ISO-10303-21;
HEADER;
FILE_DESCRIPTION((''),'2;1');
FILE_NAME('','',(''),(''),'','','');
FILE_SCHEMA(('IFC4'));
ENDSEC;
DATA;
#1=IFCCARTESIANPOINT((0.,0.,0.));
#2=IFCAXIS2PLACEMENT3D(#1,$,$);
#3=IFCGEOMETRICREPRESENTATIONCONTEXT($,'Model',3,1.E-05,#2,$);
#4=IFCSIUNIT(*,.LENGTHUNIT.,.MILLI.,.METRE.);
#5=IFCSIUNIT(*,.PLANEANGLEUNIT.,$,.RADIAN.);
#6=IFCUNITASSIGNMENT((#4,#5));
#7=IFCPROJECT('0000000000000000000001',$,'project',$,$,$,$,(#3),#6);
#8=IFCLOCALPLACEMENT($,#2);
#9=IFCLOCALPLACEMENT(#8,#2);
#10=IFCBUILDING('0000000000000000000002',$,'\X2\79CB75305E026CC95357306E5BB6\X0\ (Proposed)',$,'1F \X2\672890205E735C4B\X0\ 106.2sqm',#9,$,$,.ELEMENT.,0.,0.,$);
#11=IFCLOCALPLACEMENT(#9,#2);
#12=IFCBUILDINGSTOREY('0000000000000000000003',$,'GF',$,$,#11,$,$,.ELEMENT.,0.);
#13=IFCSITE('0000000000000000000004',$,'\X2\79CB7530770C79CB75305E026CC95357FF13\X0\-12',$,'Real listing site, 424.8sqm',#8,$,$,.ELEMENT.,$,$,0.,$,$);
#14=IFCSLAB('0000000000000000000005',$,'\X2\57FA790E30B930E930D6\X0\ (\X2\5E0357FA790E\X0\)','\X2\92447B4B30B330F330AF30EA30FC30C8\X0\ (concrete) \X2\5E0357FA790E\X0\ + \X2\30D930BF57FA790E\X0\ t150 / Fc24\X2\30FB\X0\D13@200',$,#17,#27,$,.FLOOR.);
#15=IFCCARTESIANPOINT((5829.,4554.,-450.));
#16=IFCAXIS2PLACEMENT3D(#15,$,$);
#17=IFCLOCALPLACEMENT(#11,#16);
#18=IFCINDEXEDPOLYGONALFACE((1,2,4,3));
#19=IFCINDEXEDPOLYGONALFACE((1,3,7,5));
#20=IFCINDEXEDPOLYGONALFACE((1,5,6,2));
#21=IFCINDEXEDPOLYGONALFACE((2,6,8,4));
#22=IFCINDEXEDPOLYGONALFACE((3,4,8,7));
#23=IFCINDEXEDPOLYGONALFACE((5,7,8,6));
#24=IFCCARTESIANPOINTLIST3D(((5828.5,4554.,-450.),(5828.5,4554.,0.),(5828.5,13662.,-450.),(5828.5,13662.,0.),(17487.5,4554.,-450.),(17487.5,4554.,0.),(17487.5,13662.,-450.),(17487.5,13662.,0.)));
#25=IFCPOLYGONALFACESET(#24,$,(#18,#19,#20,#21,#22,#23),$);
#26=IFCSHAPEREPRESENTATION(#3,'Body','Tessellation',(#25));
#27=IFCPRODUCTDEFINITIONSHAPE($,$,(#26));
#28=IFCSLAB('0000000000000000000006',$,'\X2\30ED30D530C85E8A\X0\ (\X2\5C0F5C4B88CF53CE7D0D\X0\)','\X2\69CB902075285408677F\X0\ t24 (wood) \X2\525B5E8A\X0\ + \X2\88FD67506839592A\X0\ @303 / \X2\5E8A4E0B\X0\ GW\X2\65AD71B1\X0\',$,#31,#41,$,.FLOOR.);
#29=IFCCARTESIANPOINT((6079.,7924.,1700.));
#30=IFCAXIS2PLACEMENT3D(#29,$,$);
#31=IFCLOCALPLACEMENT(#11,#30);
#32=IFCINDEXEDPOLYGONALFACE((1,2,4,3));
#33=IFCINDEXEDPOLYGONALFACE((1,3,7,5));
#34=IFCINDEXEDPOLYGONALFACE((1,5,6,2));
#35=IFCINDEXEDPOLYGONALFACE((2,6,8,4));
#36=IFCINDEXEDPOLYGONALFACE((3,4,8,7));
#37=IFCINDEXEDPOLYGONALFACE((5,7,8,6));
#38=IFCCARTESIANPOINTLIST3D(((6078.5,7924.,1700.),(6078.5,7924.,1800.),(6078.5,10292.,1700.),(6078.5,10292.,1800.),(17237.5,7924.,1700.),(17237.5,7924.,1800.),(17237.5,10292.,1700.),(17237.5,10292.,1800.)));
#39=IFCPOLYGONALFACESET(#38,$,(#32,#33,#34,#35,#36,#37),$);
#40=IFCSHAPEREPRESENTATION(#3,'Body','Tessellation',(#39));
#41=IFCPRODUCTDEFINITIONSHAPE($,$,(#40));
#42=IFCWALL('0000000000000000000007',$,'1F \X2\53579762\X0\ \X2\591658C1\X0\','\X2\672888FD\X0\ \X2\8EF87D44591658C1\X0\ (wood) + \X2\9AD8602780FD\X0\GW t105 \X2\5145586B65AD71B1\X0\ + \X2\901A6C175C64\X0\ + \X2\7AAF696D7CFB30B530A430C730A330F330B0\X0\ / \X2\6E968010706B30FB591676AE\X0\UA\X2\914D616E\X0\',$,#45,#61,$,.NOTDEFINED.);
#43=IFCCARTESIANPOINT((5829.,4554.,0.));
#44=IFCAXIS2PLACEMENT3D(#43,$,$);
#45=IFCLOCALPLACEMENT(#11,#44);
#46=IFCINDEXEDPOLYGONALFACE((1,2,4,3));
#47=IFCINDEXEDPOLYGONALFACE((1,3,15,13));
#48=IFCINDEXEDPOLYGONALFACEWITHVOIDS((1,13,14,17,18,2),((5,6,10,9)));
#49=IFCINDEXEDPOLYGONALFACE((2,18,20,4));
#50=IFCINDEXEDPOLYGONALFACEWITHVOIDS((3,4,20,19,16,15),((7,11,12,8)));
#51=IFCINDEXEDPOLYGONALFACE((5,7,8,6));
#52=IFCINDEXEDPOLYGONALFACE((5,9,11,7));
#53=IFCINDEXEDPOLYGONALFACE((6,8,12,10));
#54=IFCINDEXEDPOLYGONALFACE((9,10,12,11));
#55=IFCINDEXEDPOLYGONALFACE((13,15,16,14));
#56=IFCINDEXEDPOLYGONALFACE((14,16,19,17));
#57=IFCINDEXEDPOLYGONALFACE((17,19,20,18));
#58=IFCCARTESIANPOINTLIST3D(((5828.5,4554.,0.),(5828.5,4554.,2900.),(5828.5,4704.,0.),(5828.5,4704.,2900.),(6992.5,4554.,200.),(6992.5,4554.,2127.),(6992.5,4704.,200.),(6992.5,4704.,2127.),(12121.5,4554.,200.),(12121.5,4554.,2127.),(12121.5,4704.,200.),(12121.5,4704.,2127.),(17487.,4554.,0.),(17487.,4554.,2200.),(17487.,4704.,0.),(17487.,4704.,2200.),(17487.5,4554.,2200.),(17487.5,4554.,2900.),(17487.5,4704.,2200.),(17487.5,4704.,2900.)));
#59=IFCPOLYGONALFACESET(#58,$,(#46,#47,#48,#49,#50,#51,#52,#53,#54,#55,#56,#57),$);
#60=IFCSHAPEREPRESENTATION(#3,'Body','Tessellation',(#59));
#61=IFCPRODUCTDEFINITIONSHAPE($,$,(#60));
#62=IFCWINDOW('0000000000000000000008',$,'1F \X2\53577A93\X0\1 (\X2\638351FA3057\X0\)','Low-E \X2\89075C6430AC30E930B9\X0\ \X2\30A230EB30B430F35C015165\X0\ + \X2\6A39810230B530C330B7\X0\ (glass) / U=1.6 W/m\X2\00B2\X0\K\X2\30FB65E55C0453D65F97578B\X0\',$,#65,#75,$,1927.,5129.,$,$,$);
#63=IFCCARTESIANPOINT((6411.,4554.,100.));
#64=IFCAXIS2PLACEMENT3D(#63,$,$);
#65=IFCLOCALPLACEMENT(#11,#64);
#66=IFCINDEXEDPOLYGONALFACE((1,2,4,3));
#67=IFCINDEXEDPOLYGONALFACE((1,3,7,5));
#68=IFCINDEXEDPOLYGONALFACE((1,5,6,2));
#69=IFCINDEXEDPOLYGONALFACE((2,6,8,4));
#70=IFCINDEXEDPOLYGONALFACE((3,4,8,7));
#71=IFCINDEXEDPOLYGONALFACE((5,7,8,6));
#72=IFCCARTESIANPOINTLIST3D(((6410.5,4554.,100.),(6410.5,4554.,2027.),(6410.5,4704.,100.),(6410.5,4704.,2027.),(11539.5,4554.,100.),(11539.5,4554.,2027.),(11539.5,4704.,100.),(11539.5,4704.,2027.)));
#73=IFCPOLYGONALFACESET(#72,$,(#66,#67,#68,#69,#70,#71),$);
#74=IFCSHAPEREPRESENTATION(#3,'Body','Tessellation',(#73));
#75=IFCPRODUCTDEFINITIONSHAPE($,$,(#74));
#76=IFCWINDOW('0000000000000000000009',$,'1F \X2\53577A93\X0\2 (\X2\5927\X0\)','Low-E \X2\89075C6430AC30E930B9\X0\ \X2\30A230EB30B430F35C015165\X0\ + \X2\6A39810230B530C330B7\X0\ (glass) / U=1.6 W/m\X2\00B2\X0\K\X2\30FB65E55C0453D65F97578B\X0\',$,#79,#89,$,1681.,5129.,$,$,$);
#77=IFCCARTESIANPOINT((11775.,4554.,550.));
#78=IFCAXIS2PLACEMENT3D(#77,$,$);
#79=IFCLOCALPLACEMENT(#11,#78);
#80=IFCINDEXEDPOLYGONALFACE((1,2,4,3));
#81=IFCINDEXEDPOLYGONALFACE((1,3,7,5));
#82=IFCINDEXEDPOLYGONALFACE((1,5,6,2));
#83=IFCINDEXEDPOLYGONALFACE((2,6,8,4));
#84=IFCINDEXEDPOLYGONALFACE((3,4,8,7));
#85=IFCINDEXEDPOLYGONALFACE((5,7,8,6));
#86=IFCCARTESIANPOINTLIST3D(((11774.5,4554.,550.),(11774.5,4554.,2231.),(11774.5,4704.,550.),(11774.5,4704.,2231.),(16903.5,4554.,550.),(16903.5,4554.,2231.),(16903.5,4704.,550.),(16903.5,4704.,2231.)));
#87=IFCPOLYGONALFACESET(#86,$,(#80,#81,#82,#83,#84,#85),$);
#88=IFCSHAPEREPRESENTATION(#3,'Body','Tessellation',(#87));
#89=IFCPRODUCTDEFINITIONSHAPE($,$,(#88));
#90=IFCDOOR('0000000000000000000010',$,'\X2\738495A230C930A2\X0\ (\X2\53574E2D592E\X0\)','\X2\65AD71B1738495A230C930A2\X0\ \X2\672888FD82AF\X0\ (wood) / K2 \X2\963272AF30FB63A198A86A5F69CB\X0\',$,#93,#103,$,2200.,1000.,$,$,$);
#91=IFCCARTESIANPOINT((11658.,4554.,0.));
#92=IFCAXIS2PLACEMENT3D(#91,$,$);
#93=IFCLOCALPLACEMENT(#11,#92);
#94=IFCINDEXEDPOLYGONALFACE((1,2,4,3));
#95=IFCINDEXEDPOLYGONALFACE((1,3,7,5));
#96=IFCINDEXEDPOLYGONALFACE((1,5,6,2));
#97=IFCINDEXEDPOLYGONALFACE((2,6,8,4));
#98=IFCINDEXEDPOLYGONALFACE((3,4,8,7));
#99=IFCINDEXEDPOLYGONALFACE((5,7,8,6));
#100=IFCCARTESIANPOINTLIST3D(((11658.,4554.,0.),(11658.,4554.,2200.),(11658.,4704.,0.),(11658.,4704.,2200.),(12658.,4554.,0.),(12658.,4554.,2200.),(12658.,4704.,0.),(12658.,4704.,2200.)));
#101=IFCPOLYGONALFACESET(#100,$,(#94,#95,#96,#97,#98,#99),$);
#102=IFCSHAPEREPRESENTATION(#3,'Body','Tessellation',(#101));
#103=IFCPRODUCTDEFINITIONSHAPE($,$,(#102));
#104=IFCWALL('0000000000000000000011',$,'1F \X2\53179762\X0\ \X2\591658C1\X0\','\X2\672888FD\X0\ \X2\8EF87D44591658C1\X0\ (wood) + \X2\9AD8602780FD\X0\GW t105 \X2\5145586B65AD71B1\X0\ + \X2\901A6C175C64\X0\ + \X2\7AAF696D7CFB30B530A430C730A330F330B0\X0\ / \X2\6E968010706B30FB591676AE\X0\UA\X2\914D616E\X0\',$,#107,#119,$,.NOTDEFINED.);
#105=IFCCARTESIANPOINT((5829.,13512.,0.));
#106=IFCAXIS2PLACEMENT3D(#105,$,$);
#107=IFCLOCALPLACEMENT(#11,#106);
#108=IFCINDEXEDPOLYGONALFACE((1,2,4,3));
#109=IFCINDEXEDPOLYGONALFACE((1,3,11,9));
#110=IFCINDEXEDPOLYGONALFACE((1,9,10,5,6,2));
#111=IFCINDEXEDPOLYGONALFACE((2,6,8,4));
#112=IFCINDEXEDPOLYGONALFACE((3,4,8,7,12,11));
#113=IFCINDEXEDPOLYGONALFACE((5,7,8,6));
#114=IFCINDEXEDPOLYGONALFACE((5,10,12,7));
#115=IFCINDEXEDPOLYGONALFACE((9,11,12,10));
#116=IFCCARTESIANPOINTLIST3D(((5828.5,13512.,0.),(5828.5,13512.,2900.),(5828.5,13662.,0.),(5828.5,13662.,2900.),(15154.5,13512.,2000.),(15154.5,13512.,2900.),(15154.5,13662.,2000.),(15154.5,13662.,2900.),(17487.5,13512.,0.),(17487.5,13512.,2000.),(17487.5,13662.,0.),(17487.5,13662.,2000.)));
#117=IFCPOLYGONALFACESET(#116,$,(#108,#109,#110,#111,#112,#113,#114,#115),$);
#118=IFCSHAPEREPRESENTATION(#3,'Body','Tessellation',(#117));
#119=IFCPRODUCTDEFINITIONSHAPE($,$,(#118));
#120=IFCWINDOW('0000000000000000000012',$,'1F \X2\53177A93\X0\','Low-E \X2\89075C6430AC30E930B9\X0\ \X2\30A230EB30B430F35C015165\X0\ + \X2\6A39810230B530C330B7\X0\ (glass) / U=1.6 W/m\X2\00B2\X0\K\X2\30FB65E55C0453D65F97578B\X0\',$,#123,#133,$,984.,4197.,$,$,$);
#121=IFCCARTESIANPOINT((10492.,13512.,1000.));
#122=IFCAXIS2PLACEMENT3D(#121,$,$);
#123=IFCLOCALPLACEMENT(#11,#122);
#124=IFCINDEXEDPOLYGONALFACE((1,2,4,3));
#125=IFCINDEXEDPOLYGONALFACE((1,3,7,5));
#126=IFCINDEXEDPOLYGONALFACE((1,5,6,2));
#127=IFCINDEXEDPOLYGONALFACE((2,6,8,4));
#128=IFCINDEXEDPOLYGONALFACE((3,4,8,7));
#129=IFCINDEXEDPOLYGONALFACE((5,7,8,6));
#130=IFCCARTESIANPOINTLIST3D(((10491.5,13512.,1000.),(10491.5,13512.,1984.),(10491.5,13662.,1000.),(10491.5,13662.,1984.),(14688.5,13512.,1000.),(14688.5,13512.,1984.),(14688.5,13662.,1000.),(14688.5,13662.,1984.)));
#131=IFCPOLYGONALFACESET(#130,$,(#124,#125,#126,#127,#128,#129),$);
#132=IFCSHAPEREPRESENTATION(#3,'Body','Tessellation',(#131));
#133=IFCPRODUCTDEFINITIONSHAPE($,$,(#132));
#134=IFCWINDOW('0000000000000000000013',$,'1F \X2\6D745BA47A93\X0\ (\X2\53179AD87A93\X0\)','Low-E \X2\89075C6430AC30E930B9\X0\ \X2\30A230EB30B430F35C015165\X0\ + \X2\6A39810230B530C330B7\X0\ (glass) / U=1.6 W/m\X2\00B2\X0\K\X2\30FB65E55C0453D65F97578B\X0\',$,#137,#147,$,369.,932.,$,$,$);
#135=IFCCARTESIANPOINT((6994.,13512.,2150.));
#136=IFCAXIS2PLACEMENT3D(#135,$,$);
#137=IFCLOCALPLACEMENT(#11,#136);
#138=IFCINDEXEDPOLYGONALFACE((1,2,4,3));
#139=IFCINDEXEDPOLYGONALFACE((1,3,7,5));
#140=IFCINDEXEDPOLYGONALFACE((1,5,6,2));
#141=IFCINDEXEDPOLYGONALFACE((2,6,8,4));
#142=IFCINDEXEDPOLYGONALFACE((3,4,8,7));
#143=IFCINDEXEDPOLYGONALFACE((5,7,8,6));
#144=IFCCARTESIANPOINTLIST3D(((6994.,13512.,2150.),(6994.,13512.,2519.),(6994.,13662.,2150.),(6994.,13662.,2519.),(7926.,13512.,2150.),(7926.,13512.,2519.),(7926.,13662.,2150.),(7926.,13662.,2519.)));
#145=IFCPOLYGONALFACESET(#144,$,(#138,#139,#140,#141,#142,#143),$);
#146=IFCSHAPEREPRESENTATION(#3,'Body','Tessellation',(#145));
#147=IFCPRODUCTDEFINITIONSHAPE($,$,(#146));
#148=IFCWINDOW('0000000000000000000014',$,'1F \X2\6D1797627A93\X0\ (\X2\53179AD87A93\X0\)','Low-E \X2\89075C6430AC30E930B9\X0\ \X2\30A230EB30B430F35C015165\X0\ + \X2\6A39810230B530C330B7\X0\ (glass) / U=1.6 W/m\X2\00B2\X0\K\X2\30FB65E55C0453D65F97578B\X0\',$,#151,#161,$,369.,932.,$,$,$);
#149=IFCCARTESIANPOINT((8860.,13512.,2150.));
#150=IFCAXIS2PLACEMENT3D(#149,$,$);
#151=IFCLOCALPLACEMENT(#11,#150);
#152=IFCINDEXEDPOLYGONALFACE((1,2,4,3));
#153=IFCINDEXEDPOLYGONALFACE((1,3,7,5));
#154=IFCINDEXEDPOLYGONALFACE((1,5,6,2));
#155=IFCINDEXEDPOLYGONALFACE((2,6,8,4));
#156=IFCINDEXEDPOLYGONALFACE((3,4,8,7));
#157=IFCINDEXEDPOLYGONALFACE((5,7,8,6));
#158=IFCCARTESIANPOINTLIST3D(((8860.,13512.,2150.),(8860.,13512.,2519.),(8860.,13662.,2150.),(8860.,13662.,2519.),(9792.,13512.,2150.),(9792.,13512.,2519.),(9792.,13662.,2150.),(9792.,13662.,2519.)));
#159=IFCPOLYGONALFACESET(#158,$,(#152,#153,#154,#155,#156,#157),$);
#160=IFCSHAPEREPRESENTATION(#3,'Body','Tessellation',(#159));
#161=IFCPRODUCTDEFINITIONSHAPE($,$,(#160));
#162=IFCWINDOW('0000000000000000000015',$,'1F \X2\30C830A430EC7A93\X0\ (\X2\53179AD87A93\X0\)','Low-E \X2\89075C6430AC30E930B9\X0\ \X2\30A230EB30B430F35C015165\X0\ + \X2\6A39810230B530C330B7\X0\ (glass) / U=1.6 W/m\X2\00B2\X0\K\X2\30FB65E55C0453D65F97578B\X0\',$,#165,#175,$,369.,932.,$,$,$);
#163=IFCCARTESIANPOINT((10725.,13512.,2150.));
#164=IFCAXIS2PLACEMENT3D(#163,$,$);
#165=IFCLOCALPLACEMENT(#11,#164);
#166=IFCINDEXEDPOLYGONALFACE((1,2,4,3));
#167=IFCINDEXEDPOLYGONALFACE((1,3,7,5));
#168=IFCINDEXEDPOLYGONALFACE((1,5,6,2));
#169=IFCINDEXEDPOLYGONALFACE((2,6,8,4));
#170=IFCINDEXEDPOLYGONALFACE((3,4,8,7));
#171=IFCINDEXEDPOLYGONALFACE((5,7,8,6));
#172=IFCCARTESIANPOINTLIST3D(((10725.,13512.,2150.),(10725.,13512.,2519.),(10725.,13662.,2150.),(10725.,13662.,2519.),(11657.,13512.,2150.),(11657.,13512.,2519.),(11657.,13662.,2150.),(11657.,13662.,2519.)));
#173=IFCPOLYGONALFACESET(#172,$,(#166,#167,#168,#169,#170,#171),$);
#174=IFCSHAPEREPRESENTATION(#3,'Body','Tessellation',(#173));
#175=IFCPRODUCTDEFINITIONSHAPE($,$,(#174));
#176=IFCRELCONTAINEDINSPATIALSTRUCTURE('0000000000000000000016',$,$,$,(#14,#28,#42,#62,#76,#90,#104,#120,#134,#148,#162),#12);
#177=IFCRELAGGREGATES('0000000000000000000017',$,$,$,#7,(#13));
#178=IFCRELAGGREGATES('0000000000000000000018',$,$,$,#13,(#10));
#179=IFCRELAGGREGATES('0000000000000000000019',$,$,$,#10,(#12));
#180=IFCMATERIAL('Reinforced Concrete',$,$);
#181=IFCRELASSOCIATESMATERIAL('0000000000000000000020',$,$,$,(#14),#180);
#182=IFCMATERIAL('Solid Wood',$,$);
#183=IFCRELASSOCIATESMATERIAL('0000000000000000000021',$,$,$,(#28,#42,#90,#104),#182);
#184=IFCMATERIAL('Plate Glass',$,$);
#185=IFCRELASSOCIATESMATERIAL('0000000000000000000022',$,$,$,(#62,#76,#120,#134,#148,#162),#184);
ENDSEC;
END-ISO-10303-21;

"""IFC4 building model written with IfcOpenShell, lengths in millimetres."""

from ifc_helpers import new_model, si_unit, frame, frame_2d, origin, place, context, project, spatial, rectangle, extrude, material, element, fill, save


model = new_model("IFC4")

# Units and contexts
model_context = context("Model", 3, precision=1e-05, world=origin())
ifc_project = project(units=[si_unit("LENGTHUNIT", "METRE", prefix="MILLI"), si_unit("PLANEANGLEUNIT", "RADIAN")], contexts=[model_context])

# Site, building, storey
site_placement = place(None, origin())
site = spatial("IfcSite", under=ifc_project, at=site_placement, Name="秋田県秋田市泉南３-12", ObjectType="Real listing site, 424.8sqm", CompositionType="ELEMENT", RefElevation=0.0)
building_placement = place(site_placement, origin())
building = spatial("IfcBuilding", under=site, at=building_placement, Name="秋田市泉南の家 (Proposed)", ObjectType="1F 木造平屋 106.2sqm", CompositionType="ELEMENT", ElevationOfRefHeight=0.0, ElevationOfTerrain=0.0)
storey_placement = place(building_placement, origin())
storey = spatial("IfcBuildingStorey", under=building, at=storey_placement, Name="GF", CompositionType="ELEMENT", Elevation=0.0)

# Slabs
ifc_material_1 = material(Name="Reinforced Concrete")
slab_1_placement = place(storey_placement, frame((5829.0, 4554.0, -450.0)))
element("IfcSlab", 1, at=slab_1_placement, inside=storey, material=ifc_material_1, Name="基礎スラブ (布基礎)", Description="鉄筋コンクリート (concrete) 布基礎 + ベタ基礎 t150 / Fc24・D13@200", PredefinedType="FLOOR", context=model_context, shape_type="SweptSolid", body=[
    extrude(rectangle(XDim=11659.0, YDim=9108.0, at=frame_2d((5829.0, 4554.0))), frame((5829.0, 4554.0, -450.0)), (0.0, 0.0, 1.0), 450.0),
])
ifc_material_2 = material(Name="Solid Wood")
slab_2_placement = place(storey_placement, frame((6079.0, 7924.0, 1700.0)))
element("IfcSlab", 2, at=slab_2_placement, inside=storey, material=ifc_material_2, Name="ロフト床 (小屋裏収納)", Description="構造用合板 t24 (wood) 剛床 + 製材根太 @303 / 床下 GW断熱", PredefinedType="FLOOR", context=model_context, shape_type="SweptSolid", body=[
    extrude(rectangle(XDim=11159.0, YDim=2368.0, at=frame_2d((5579.0, 1184.0))), frame((6079.0, 7924.0, 1700.0)), (0.0, 0.0, 1.0), 100.0),
])

# Wall, openings, windows, door
wall_1_placement = place(storey_placement, frame((5829.0, 4554.0, 0.0)))
wall_1 = element("IfcWall", 3, at=wall_1_placement, inside=storey, material=ifc_material_2, Name="1F 南面 外壁", Description="木製 軸組外壁 (wood) + 高性能GW t105 充填断熱 + 通気層 + 窯業系サイディング / 準耐火・外皮UA配慮", PredefinedType="NOTDEFINED", context=model_context, shape_type="SweptSolid", body=[
    extrude(rectangle(XDim=11659.0, YDim=150.0, at=frame_2d((5829.0, 75.0))), frame((5829.0, 4554.0, 0.0)), (0.0, 0.0, 1.0), 2900.0),
])
opening_1_placement = place(storey_placement, frame((6411.0, 4554.0, 100.0)))
opening_1 = element("IfcOpeningElement", 4, at=opening_1_placement, cuts=wall_1, PredefinedType="NOTDEFINED", context=model_context, shape_type="SweptSolid", body=[
    extrude(rectangle(XDim=5129.0, YDim=150.0, at=frame_2d((2564.0, 75.0))), frame((6411.0, 4554.0, 100.0)), (0.0, 0.0, 1.0), 1927.0),
])
opening_2_placement = place(storey_placement, frame((11775.0, 4554.0, 550.0)))
opening_2 = element("IfcOpeningElement", 5, at=opening_2_placement, cuts=wall_1, PredefinedType="NOTDEFINED", context=model_context, shape_type="SweptSolid", body=[
    extrude(rectangle(XDim=5129.0, YDim=150.0, at=frame_2d((2564.0, 75.0))), frame((11775.0, 4554.0, 550.0)), (0.0, 0.0, 1.0), 1681.0),
])
opening_3_placement = place(storey_placement, frame((11658.0, 4554.0, 0.0)))
opening_3 = element("IfcOpeningElement", 6, at=opening_3_placement, cuts=wall_1, PredefinedType="NOTDEFINED", context=model_context, shape_type="SweptSolid", body=[
    extrude(rectangle(XDim=1000.0, YDim=150.0, at=frame_2d((500.0, 75.0))), frame((11658.0, 4554.0, 0.0)), (0.0, 0.0, 1.0), 2200.0),
])
ifc_material_3 = material(Name="Plate Glass")
window_1_placement = place(storey_placement, frame((6411.0, 4554.0, 100.0)))
window_1 = element("IfcWindow", 7, at=window_1_placement, inside=storey, material=ifc_material_3, Name="1F 南窓1 (掃出し)", Description="Low-E 複層ガラス アルゴン封入 + 樹脂サッシ (glass) / U=1.6 W/m²K・日射取得型", OverallHeight=1927.0, OverallWidth=5129.0, context=model_context, shape_type="SweptSolid", body=[
    extrude(rectangle(XDim=5129.0, YDim=150.0, at=frame_2d((2564.0, 75.0))), frame((6411.0, 4554.0, 100.0)), (0.0, 0.0, 1.0), 1927.0),
])
fill(opening_1, window_1)
window_2_placement = place(storey_placement, frame((11775.0, 4554.0, 550.0)))
window_2 = element("IfcWindow", 8, at=window_2_placement, inside=storey, material=ifc_material_3, Name="1F 南窓2 (大)", Description="Low-E 複層ガラス アルゴン封入 + 樹脂サッシ (glass) / U=1.6 W/m²K・日射取得型", OverallHeight=1681.0, OverallWidth=5129.0, context=model_context, shape_type="SweptSolid", body=[
    extrude(rectangle(XDim=5129.0, YDim=150.0, at=frame_2d((2564.0, 75.0))), frame((11775.0, 4554.0, 550.0)), (0.0, 0.0, 1.0), 1681.0),
])
fill(opening_2, window_2)
door_1_placement = place(storey_placement, frame((11658.0, 4554.0, 0.0)))
door_1 = element("IfcDoor", 9, at=door_1_placement, inside=storey, material=ifc_material_2, Name="玄関ドア (南中央)", Description="断熱玄関ドア 木製芯 (wood) / K2 防犯・採風機構", OverallHeight=2200.0, OverallWidth=1000.0, context=model_context, shape_type="SweptSolid", body=[
    extrude(rectangle(XDim=1000.0, YDim=150.0, at=frame_2d((500.0, 75.0))), frame((11658.0, 4554.0, 0.0)), (0.0, 0.0, 1.0), 2200.0),
])
fill(opening_3, door_1)

# Wall, openings, windows
wall_2_placement = place(storey_placement, frame((5829.0, 13512.0, 0.0)))
wall_2 = element("IfcWall", 10, at=wall_2_placement, inside=storey, material=ifc_material_2, Name="1F 北面 外壁", Description="木製 軸組外壁 (wood) + 高性能GW t105 充填断熱 + 通気層 + 窯業系サイディング / 準耐火・外皮UA配慮", PredefinedType="NOTDEFINED", context=model_context, shape_type="SweptSolid", body=[
    extrude(rectangle(XDim=11659.0, YDim=150.0, at=frame_2d((5829.0, 75.0))), frame((5829.0, 13512.0, 0.0)), (0.0, 0.0, 1.0), 2900.0),
])
opening_4_placement = place(storey_placement, frame((10492.0, 13512.0, 1000.0)))
opening_4 = element("IfcOpeningElement", 11, at=opening_4_placement, cuts=wall_2, PredefinedType="NOTDEFINED", context=model_context, shape_type="SweptSolid", body=[
    extrude(rectangle(XDim=4197.0, YDim=150.0, at=frame_2d((2098.0, 75.0))), frame((10492.0, 13512.0, 1000.0)), (0.0, 0.0, 1.0), 984.0),
])
opening_5_placement = place(storey_placement, frame((6994.0, 13512.0, 2150.0)))
opening_5 = element("IfcOpeningElement", 12, at=opening_5_placement, cuts=wall_2, PredefinedType="NOTDEFINED", context=model_context, shape_type="SweptSolid", body=[
    extrude(rectangle(XDim=932.0, YDim=150.0, at=frame_2d((466.0, 75.0))), frame((6994.0, 13512.0, 2150.0)), (0.0, 0.0, 1.0), 369.0),
])
opening_6_placement = place(storey_placement, frame((8860.0, 13512.0, 2150.0)))
opening_6 = element("IfcOpeningElement", 13, at=opening_6_placement, cuts=wall_2, PredefinedType="NOTDEFINED", context=model_context, shape_type="SweptSolid", body=[
    extrude(rectangle(XDim=932.0, YDim=150.0, at=frame_2d((466.0, 75.0))), frame((8860.0, 13512.0, 2150.0)), (0.0, 0.0, 1.0), 369.0),
])
opening_7_placement = place(storey_placement, frame((10725.0, 13512.0, 2150.0)))
opening_7 = element("IfcOpeningElement", 14, at=opening_7_placement, cuts=wall_2, PredefinedType="NOTDEFINED", context=model_context, shape_type="SweptSolid", body=[
    extrude(rectangle(XDim=932.0, YDim=150.0, at=frame_2d((466.0, 75.0))), frame((10725.0, 13512.0, 2150.0)), (0.0, 0.0, 1.0), 369.0),
])
window_3_placement = place(storey_placement, frame((10492.0, 13512.0, 1000.0)))
window_3 = element("IfcWindow", 15, at=window_3_placement, inside=storey, material=ifc_material_3, Name="1F 北窓", Description="Low-E 複層ガラス アルゴン封入 + 樹脂サッシ (glass) / U=1.6 W/m²K・日射取得型", OverallHeight=984.0, OverallWidth=4197.0, context=model_context, shape_type="SweptSolid", body=[
    extrude(rectangle(XDim=4197.0, YDim=150.0, at=frame_2d((2098.0, 75.0))), frame((10492.0, 13512.0, 1000.0)), (0.0, 0.0, 1.0), 984.0),
])
fill(opening_4, window_3)
window_4_placement = place(storey_placement, frame((6994.0, 13512.0, 2150.0)))
window_4 = element("IfcWindow", 16, at=window_4_placement, inside=storey, material=ifc_material_3, Name="1F 浴室窓 (北高窓)", Description="Low-E 複層ガラス アルゴン封入 + 樹脂サッシ (glass) / U=1.6 W/m²K・日射取得型", OverallHeight=369.0, OverallWidth=932.0, context=model_context, shape_type="SweptSolid", body=[
    extrude(rectangle(XDim=932.0, YDim=150.0, at=frame_2d((466.0, 75.0))), frame((6994.0, 13512.0, 2150.0)), (0.0, 0.0, 1.0), 369.0),
])
fill(opening_5, window_4)
window_5_placement = place(storey_placement, frame((8860.0, 13512.0, 2150.0)))
window_5 = element("IfcWindow", 17, at=window_5_placement, inside=storey, material=ifc_material_3, Name="1F 洗面窓 (北高窓)", Description="Low-E 複層ガラス アルゴン封入 + 樹脂サッシ (glass) / U=1.6 W/m²K・日射取得型", OverallHeight=369.0, OverallWidth=932.0, context=model_context, shape_type="SweptSolid", body=[
    extrude(rectangle(XDim=932.0, YDim=150.0, at=frame_2d((466.0, 75.0))), frame((8860.0, 13512.0, 2150.0)), (0.0, 0.0, 1.0), 369.0),
])
fill(opening_6, window_5)
window_6_placement = place(storey_placement, frame((10725.0, 13512.0, 2150.0)))
window_6 = element("IfcWindow", 18, at=window_6_placement, inside=storey, material=ifc_material_3, Name="1F トイレ窓 (北高窓)", Description="Low-E 複層ガラス アルゴン封入 + 樹脂サッシ (glass) / U=1.6 W/m²K・日射取得型", OverallHeight=369.0, OverallWidth=932.0, context=model_context, shape_type="SweptSolid", body=[
    extrude(rectangle(XDim=932.0, YDim=150.0, at=frame_2d((466.0, 75.0))), frame((10725.0, 13512.0, 2150.0)), (0.0, 0.0, 1.0), 369.0),
])
fill(opening_7, window_6)

save(model, "model.ifc")
